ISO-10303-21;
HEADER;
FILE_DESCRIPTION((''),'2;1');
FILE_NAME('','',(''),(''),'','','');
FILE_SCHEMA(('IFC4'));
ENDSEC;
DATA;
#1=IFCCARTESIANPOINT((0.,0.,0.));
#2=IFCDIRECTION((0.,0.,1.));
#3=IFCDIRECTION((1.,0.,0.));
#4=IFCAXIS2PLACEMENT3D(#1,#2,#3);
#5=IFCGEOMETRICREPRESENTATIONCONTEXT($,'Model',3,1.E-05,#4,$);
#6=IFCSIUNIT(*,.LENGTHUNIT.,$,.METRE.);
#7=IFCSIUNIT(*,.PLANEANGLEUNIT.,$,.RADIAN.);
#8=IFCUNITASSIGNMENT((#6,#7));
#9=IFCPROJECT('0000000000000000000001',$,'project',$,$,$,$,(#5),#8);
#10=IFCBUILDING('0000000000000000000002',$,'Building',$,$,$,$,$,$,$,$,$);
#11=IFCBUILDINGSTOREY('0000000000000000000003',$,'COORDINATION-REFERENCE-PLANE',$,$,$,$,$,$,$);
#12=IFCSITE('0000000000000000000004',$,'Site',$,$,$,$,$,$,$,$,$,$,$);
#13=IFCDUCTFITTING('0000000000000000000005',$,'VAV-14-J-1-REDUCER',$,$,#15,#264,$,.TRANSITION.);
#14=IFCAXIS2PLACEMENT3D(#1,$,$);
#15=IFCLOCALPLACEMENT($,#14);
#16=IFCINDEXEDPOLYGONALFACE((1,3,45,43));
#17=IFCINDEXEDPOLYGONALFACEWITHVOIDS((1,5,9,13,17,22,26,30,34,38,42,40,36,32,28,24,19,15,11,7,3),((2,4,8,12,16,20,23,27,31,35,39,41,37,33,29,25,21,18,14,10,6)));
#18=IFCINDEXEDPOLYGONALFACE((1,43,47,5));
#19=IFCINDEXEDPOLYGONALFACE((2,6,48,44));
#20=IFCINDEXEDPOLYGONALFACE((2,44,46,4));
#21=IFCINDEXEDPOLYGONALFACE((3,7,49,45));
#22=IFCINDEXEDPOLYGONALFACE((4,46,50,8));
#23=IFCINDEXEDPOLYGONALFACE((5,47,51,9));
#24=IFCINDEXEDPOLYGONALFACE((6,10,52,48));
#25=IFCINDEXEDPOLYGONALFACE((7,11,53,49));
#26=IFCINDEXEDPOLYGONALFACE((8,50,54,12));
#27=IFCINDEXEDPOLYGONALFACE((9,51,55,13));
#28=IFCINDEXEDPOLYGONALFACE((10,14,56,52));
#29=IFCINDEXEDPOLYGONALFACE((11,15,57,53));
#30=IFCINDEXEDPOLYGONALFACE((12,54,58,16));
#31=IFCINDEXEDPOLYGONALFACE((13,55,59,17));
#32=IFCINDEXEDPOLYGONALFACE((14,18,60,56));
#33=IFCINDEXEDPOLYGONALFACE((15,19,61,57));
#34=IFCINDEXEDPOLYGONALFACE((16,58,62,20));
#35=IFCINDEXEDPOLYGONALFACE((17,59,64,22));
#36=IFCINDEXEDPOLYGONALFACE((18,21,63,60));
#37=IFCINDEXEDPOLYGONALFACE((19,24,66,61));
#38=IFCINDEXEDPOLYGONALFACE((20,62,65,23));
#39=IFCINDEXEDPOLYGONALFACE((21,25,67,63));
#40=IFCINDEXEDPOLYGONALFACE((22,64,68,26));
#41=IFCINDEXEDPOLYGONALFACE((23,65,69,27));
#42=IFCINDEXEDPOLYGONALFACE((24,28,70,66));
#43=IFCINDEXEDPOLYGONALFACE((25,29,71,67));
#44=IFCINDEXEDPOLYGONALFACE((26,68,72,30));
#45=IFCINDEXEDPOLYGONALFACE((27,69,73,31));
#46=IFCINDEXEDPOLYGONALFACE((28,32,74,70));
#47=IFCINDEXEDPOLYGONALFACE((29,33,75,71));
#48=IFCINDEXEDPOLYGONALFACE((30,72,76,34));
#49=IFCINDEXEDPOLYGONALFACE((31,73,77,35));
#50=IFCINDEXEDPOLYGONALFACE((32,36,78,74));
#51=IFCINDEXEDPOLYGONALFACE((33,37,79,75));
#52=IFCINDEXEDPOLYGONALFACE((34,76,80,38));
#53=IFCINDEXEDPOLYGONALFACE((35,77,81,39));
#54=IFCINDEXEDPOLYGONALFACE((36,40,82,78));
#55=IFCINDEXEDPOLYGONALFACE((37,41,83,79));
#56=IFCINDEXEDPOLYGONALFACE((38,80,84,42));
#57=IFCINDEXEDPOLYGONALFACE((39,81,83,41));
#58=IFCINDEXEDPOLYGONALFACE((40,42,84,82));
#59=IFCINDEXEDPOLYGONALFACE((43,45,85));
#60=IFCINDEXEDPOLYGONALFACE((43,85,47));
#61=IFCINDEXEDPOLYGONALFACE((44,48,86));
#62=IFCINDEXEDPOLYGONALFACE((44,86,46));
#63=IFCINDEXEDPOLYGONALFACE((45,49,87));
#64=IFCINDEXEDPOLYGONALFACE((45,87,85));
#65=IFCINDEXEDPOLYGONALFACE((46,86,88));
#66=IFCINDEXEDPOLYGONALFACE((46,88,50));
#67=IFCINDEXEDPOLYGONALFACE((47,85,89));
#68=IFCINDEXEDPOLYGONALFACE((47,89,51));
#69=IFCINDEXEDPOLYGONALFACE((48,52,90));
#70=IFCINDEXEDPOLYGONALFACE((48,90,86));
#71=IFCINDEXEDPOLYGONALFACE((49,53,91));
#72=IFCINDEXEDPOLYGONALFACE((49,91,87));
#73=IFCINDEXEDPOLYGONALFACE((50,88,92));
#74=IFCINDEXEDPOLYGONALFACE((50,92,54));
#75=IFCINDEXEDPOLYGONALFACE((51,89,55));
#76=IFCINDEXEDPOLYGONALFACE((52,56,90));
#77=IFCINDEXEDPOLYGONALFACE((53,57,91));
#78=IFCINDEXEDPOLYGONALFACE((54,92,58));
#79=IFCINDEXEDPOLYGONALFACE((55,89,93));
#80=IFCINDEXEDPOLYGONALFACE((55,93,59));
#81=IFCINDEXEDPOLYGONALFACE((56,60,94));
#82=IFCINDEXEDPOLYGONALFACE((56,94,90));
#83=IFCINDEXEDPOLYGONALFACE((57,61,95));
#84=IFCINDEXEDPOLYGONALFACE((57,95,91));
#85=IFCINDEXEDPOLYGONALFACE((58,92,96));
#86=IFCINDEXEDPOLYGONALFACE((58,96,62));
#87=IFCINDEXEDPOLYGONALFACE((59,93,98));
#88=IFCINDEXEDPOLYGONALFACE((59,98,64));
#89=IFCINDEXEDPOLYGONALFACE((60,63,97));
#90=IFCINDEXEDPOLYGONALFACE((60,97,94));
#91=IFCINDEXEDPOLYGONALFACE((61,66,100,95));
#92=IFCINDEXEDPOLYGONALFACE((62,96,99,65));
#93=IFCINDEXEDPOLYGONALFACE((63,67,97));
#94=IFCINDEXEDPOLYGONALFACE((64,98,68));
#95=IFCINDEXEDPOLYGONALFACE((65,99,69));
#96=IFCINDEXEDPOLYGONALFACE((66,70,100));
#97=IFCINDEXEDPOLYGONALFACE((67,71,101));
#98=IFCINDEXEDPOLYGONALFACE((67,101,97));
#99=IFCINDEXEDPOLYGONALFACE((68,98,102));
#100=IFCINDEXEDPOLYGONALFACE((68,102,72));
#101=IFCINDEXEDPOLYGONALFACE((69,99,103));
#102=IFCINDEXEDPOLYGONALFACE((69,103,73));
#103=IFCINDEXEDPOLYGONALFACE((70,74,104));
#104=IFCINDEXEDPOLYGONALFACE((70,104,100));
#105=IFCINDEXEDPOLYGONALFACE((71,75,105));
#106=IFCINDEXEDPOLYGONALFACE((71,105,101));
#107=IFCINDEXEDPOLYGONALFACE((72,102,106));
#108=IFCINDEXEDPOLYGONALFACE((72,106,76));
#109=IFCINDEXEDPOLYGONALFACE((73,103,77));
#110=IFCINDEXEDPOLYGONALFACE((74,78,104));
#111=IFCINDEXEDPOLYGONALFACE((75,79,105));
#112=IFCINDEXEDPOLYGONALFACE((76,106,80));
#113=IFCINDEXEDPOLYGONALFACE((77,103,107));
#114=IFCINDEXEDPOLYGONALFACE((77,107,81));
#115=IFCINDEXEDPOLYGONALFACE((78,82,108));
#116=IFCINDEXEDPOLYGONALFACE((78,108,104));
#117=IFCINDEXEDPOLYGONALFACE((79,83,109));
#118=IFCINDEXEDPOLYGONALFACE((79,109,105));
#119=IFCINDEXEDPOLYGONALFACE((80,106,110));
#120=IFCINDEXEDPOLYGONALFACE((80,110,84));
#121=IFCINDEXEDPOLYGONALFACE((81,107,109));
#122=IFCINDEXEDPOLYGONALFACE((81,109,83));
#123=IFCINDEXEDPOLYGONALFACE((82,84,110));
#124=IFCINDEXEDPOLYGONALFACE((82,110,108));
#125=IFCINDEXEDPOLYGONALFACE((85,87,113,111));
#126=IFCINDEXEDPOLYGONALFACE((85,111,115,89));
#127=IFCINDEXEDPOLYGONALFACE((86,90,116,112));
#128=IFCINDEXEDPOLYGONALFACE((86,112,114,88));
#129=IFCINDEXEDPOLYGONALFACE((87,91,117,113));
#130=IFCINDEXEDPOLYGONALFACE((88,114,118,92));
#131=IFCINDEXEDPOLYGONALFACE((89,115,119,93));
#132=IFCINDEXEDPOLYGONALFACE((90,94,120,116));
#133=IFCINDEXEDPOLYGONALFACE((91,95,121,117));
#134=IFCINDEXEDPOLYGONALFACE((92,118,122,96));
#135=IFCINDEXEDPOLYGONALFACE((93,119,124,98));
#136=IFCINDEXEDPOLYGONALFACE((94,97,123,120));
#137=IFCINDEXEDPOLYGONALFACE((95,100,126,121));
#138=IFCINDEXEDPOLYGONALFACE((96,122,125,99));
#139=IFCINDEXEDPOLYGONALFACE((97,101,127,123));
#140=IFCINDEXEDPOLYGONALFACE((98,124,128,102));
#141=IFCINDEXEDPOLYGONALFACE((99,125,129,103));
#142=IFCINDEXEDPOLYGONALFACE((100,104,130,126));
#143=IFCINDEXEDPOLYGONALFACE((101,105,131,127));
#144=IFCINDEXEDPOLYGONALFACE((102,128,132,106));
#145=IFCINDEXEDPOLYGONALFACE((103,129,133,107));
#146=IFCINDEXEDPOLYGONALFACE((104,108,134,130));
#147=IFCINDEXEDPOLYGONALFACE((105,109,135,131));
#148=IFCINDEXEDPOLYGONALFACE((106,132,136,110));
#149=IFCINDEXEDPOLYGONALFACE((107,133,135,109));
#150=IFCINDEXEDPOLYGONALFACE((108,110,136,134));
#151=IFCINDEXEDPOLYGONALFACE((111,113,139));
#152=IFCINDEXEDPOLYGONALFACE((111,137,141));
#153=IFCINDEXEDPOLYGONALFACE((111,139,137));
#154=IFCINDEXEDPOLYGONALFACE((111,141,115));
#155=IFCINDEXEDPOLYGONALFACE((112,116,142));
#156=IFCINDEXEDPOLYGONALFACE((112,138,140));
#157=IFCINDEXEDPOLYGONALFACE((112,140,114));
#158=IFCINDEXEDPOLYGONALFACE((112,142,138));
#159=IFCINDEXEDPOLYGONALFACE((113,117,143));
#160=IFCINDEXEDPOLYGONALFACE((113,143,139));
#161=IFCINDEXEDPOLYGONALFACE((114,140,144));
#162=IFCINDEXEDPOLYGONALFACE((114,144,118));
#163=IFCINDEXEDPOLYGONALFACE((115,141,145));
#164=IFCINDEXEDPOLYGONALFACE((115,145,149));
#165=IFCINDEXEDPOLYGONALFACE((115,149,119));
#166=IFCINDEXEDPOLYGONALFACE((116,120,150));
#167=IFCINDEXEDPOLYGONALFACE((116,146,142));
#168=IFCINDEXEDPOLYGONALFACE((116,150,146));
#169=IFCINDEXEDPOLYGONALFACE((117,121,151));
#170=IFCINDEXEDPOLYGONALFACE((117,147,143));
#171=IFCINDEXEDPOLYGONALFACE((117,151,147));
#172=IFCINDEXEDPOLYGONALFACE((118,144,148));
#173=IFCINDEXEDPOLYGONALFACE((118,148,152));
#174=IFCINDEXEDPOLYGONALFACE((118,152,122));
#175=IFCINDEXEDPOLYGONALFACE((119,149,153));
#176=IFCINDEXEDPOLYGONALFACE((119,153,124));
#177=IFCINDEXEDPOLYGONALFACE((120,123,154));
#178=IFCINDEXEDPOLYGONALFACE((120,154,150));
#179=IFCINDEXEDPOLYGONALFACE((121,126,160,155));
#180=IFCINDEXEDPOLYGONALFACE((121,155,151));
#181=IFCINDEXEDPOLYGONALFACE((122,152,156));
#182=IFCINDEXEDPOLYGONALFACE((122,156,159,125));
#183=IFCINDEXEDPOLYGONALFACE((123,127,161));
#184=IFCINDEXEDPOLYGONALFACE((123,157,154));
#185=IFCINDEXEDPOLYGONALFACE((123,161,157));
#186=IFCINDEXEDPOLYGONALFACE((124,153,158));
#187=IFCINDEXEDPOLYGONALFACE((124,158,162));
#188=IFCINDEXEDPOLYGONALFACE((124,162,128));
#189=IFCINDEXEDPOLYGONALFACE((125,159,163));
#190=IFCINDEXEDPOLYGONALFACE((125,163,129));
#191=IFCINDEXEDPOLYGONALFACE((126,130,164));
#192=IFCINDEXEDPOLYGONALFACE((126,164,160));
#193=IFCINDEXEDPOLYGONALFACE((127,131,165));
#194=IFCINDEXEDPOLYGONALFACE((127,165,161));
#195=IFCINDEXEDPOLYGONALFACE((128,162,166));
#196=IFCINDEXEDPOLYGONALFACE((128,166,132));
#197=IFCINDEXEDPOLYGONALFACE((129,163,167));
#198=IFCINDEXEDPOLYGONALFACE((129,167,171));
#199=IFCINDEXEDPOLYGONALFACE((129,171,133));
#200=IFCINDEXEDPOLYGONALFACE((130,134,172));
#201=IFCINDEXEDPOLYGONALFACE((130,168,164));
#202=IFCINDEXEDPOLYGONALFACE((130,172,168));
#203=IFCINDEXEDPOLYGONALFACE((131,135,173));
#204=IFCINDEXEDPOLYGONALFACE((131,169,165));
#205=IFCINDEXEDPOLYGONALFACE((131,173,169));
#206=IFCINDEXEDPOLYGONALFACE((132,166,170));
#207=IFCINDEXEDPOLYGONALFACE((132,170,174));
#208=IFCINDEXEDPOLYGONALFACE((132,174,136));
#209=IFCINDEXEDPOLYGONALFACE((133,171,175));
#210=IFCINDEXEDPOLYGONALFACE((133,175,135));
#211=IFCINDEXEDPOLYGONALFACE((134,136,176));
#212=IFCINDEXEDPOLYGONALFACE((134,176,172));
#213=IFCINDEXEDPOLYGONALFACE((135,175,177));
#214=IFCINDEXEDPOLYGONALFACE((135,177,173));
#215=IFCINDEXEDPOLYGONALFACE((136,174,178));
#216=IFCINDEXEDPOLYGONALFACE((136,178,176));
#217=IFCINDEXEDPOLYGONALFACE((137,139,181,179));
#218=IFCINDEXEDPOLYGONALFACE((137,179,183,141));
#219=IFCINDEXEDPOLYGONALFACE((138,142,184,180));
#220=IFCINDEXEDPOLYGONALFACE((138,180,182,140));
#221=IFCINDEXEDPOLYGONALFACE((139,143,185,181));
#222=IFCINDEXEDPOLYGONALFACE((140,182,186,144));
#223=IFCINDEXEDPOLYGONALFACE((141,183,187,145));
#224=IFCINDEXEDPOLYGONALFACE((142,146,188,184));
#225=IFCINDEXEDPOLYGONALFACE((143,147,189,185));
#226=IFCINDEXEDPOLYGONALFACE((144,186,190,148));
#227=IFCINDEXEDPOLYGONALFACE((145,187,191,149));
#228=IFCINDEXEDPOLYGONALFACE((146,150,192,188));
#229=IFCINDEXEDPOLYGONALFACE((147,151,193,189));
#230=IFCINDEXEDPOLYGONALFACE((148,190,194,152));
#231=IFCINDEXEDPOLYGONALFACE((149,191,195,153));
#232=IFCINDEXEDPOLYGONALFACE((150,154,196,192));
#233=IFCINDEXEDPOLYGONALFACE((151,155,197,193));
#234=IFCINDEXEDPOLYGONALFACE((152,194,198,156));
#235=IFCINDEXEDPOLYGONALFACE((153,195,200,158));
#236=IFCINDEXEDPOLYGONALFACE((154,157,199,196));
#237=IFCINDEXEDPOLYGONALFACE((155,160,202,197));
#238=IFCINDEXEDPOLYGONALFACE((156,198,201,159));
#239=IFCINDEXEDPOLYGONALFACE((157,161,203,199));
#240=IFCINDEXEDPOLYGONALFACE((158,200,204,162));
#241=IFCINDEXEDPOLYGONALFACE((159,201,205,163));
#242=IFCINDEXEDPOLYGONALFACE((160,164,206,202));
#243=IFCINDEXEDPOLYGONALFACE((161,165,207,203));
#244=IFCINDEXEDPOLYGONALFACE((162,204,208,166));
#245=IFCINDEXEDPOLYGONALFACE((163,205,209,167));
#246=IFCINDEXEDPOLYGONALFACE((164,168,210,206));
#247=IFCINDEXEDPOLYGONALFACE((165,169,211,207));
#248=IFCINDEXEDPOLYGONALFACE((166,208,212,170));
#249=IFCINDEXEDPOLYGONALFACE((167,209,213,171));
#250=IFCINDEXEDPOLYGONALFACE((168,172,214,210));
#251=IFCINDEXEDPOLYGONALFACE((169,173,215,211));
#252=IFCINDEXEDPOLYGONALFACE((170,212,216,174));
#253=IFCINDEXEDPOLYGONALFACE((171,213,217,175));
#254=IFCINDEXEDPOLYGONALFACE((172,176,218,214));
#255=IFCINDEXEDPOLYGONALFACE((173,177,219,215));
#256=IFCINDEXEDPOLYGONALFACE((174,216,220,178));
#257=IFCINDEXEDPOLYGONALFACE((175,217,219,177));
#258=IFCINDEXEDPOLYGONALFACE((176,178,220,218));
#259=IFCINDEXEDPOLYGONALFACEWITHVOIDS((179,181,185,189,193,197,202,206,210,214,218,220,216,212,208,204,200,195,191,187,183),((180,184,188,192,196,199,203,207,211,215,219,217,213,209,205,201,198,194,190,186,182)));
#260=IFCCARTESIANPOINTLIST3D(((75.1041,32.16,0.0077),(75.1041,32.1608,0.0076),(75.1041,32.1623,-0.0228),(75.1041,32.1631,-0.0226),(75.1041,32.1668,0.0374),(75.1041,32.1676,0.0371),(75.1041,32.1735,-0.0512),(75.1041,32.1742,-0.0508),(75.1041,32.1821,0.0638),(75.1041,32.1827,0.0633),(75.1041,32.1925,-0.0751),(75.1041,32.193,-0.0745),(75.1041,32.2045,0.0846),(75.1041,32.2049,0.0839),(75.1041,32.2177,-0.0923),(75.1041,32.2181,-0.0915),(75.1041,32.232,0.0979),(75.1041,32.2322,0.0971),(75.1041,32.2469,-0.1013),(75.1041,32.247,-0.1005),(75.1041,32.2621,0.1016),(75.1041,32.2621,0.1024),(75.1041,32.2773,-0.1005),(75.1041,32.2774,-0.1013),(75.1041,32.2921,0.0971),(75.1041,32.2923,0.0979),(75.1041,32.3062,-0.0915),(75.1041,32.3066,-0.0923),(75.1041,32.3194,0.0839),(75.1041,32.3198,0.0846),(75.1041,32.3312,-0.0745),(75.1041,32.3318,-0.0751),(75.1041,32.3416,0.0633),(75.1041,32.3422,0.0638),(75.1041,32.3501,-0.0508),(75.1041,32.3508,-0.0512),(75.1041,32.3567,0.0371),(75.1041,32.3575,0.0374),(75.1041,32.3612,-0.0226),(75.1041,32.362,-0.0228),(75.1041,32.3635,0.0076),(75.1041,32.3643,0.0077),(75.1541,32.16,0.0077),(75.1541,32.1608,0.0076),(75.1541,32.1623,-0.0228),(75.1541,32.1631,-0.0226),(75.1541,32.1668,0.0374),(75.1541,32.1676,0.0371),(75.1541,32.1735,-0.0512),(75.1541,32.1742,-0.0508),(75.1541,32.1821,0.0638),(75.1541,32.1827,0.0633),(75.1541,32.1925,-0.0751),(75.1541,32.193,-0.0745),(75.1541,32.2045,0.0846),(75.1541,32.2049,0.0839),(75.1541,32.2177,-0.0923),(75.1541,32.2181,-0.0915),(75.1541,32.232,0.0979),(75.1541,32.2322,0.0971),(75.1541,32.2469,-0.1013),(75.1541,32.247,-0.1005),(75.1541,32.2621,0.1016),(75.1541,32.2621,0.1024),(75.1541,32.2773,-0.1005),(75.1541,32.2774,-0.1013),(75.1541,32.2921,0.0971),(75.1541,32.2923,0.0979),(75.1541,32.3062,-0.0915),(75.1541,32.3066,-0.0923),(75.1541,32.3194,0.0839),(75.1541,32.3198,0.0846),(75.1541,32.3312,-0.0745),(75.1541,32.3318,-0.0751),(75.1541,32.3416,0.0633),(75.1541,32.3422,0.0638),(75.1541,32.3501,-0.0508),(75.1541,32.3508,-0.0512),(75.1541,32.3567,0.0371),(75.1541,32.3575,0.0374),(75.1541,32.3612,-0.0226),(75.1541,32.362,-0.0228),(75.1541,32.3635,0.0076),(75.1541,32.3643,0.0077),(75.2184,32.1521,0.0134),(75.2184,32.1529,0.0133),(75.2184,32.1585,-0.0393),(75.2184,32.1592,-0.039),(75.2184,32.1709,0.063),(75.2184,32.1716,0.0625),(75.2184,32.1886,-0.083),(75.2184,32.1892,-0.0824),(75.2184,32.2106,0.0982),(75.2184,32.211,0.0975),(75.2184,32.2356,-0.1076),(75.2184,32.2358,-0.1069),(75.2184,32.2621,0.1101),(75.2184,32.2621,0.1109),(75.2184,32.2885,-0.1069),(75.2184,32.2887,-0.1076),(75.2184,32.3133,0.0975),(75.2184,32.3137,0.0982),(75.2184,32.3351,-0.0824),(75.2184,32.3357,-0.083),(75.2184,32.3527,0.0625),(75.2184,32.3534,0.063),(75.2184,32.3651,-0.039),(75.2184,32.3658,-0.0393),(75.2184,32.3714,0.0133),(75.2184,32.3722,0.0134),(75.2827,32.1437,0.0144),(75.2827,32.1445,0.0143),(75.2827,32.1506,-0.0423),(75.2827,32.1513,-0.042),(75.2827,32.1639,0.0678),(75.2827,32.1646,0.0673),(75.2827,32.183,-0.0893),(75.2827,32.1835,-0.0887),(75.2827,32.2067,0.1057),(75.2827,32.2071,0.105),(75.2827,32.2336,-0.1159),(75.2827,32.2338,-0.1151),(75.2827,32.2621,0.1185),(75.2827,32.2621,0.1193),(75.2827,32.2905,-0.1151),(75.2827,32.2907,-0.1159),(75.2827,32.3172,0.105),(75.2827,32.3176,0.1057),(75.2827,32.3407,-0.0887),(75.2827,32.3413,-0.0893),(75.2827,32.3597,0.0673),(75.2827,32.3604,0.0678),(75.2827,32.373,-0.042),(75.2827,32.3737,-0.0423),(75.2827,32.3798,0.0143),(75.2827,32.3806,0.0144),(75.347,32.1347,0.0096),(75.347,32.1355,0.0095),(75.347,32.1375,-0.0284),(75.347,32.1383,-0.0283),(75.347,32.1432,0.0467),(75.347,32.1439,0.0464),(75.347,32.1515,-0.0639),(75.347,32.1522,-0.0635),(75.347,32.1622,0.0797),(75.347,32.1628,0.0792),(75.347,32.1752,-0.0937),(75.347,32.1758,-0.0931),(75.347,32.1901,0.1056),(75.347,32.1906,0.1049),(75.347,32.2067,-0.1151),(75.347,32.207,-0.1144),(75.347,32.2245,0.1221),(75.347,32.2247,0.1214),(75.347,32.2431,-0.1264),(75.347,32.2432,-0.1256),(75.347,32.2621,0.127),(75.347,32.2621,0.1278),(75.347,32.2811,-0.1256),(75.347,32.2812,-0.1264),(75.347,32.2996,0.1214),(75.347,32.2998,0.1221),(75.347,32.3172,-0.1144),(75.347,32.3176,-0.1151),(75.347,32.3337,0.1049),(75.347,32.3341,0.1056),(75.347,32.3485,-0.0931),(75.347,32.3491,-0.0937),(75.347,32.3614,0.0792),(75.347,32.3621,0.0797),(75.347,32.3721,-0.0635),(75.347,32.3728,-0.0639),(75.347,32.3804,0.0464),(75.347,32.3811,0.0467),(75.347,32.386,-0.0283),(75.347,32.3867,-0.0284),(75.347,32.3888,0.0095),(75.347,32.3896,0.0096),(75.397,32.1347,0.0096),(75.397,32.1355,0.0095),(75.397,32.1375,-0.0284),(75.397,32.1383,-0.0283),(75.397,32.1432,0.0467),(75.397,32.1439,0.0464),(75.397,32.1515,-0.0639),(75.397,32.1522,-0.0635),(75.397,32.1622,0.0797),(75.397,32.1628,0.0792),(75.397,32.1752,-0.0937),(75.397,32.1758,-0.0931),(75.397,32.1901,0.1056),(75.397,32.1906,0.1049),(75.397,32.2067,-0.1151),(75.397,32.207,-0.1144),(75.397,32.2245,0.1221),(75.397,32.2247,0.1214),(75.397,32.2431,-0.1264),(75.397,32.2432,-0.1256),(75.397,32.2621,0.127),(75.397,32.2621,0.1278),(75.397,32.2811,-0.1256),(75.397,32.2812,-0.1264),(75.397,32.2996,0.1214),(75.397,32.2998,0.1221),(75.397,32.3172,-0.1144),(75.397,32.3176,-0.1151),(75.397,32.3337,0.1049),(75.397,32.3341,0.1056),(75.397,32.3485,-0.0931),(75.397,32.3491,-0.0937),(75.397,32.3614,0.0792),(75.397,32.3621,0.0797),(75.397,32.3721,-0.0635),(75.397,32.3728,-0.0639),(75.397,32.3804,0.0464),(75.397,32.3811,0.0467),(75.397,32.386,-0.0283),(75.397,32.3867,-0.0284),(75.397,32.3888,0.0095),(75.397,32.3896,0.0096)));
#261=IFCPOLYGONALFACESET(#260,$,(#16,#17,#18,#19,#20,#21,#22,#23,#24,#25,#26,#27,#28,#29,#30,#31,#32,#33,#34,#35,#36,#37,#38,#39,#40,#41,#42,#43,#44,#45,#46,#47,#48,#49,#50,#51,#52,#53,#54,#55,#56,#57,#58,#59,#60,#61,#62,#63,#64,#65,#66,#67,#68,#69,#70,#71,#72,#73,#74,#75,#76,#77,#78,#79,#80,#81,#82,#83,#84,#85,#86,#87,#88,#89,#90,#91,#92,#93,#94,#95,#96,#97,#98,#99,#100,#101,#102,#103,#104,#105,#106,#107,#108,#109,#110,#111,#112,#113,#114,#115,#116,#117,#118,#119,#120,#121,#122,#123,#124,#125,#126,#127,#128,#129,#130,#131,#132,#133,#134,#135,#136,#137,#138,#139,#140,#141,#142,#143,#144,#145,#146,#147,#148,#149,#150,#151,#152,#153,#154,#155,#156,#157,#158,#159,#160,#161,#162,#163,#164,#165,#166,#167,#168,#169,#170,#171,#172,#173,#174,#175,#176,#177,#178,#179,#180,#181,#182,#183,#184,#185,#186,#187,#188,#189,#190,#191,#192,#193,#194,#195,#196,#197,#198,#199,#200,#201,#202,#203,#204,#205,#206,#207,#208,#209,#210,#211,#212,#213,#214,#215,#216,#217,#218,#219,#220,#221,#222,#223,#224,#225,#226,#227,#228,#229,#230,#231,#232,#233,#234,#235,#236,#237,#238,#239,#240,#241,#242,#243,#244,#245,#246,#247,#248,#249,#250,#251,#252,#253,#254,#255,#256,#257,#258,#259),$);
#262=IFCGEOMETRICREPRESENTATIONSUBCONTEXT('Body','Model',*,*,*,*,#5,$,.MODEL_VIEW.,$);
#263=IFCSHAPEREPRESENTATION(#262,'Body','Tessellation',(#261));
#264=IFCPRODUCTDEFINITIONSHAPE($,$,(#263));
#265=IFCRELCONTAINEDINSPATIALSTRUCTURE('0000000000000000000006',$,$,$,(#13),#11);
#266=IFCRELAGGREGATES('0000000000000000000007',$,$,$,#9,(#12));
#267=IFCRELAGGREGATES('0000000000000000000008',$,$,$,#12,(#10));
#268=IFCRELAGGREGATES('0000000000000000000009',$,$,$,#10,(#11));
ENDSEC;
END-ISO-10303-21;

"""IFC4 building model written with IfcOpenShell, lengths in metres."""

from ifc_helpers import new_model, entity, si_unit, frame, origin_with_axes, place, context, subcontext, project, spatial, element, save


model = new_model("IFC4")

# Units and contexts
model_context = context("Model", 3, precision=1e-05, world=origin_with_axes())
body_context_1 = subcontext(model_context, "Body", "Model", "MODEL_VIEW")
ifc_project = project(units=[si_unit("LENGTHUNIT", "METRE"), si_unit("PLANEANGLEUNIT", "RADIAN")], contexts=[model_context])

# Site, building, storey
site = spatial("IfcSite", under=ifc_project, Name="Site")
building = spatial("IfcBuilding", under=site, Name="Building")
storey = spatial("IfcBuildingStorey", under=building, Name="COORDINATION-REFERENCE-PLANE")

# Duct fitting
for number, where, z_axis, x_axis, name in (
    (1, (75.397, 32.2621, 0.0), (0.0, -1.0, 0.0), (0.0, 0.0, 1.0), "VAV-14-J-1-REDUCER"),
):
    element("IfcDuctFitting", number, at=place(None, frame(where, z_axis=z_axis, x_axis=x_axis)), inside=storey, Name=name, PredefinedType="TRANSITION", context=body_context_1, shape_type="SweptSolid", body=[
        entity("IfcRevolvedAreaSolid", entity("IfcArbitraryClosedProfileDef", "AREA", None, entity("IfcPolyline", [entity("IfcCartesianPoint", [0.1278, 0.0]), entity("IfcCartesianPoint", [0.1278, 0.05]), entity("IfcCartesianPoint", [0.1024, 0.2429]), entity("IfcCartesianPoint", [0.1024, 0.2929]), entity("IfcCartesianPoint", [0.1016, 0.2929]), entity("IfcCartesianPoint", [0.1016, 0.2429]), entity("IfcCartesianPoint", [0.127, 0.05]), entity("IfcCartesianPoint", [0.127, 0.0]), entity("IfcCartesianPoint", [0.1278, 0.0])])), entity("IfcAxis2Placement3D", entity("IfcCartesianPoint", [0.0, 0.0, 0.0])), entity("IfcAxis1Placement", entity("IfcCartesianPoint", [0.0, 0.0, 0.0]), entity("IfcDirection", [0.0, 1.0, 0.0])), 6.283185),
    ])

save(model, "model.ifc")
